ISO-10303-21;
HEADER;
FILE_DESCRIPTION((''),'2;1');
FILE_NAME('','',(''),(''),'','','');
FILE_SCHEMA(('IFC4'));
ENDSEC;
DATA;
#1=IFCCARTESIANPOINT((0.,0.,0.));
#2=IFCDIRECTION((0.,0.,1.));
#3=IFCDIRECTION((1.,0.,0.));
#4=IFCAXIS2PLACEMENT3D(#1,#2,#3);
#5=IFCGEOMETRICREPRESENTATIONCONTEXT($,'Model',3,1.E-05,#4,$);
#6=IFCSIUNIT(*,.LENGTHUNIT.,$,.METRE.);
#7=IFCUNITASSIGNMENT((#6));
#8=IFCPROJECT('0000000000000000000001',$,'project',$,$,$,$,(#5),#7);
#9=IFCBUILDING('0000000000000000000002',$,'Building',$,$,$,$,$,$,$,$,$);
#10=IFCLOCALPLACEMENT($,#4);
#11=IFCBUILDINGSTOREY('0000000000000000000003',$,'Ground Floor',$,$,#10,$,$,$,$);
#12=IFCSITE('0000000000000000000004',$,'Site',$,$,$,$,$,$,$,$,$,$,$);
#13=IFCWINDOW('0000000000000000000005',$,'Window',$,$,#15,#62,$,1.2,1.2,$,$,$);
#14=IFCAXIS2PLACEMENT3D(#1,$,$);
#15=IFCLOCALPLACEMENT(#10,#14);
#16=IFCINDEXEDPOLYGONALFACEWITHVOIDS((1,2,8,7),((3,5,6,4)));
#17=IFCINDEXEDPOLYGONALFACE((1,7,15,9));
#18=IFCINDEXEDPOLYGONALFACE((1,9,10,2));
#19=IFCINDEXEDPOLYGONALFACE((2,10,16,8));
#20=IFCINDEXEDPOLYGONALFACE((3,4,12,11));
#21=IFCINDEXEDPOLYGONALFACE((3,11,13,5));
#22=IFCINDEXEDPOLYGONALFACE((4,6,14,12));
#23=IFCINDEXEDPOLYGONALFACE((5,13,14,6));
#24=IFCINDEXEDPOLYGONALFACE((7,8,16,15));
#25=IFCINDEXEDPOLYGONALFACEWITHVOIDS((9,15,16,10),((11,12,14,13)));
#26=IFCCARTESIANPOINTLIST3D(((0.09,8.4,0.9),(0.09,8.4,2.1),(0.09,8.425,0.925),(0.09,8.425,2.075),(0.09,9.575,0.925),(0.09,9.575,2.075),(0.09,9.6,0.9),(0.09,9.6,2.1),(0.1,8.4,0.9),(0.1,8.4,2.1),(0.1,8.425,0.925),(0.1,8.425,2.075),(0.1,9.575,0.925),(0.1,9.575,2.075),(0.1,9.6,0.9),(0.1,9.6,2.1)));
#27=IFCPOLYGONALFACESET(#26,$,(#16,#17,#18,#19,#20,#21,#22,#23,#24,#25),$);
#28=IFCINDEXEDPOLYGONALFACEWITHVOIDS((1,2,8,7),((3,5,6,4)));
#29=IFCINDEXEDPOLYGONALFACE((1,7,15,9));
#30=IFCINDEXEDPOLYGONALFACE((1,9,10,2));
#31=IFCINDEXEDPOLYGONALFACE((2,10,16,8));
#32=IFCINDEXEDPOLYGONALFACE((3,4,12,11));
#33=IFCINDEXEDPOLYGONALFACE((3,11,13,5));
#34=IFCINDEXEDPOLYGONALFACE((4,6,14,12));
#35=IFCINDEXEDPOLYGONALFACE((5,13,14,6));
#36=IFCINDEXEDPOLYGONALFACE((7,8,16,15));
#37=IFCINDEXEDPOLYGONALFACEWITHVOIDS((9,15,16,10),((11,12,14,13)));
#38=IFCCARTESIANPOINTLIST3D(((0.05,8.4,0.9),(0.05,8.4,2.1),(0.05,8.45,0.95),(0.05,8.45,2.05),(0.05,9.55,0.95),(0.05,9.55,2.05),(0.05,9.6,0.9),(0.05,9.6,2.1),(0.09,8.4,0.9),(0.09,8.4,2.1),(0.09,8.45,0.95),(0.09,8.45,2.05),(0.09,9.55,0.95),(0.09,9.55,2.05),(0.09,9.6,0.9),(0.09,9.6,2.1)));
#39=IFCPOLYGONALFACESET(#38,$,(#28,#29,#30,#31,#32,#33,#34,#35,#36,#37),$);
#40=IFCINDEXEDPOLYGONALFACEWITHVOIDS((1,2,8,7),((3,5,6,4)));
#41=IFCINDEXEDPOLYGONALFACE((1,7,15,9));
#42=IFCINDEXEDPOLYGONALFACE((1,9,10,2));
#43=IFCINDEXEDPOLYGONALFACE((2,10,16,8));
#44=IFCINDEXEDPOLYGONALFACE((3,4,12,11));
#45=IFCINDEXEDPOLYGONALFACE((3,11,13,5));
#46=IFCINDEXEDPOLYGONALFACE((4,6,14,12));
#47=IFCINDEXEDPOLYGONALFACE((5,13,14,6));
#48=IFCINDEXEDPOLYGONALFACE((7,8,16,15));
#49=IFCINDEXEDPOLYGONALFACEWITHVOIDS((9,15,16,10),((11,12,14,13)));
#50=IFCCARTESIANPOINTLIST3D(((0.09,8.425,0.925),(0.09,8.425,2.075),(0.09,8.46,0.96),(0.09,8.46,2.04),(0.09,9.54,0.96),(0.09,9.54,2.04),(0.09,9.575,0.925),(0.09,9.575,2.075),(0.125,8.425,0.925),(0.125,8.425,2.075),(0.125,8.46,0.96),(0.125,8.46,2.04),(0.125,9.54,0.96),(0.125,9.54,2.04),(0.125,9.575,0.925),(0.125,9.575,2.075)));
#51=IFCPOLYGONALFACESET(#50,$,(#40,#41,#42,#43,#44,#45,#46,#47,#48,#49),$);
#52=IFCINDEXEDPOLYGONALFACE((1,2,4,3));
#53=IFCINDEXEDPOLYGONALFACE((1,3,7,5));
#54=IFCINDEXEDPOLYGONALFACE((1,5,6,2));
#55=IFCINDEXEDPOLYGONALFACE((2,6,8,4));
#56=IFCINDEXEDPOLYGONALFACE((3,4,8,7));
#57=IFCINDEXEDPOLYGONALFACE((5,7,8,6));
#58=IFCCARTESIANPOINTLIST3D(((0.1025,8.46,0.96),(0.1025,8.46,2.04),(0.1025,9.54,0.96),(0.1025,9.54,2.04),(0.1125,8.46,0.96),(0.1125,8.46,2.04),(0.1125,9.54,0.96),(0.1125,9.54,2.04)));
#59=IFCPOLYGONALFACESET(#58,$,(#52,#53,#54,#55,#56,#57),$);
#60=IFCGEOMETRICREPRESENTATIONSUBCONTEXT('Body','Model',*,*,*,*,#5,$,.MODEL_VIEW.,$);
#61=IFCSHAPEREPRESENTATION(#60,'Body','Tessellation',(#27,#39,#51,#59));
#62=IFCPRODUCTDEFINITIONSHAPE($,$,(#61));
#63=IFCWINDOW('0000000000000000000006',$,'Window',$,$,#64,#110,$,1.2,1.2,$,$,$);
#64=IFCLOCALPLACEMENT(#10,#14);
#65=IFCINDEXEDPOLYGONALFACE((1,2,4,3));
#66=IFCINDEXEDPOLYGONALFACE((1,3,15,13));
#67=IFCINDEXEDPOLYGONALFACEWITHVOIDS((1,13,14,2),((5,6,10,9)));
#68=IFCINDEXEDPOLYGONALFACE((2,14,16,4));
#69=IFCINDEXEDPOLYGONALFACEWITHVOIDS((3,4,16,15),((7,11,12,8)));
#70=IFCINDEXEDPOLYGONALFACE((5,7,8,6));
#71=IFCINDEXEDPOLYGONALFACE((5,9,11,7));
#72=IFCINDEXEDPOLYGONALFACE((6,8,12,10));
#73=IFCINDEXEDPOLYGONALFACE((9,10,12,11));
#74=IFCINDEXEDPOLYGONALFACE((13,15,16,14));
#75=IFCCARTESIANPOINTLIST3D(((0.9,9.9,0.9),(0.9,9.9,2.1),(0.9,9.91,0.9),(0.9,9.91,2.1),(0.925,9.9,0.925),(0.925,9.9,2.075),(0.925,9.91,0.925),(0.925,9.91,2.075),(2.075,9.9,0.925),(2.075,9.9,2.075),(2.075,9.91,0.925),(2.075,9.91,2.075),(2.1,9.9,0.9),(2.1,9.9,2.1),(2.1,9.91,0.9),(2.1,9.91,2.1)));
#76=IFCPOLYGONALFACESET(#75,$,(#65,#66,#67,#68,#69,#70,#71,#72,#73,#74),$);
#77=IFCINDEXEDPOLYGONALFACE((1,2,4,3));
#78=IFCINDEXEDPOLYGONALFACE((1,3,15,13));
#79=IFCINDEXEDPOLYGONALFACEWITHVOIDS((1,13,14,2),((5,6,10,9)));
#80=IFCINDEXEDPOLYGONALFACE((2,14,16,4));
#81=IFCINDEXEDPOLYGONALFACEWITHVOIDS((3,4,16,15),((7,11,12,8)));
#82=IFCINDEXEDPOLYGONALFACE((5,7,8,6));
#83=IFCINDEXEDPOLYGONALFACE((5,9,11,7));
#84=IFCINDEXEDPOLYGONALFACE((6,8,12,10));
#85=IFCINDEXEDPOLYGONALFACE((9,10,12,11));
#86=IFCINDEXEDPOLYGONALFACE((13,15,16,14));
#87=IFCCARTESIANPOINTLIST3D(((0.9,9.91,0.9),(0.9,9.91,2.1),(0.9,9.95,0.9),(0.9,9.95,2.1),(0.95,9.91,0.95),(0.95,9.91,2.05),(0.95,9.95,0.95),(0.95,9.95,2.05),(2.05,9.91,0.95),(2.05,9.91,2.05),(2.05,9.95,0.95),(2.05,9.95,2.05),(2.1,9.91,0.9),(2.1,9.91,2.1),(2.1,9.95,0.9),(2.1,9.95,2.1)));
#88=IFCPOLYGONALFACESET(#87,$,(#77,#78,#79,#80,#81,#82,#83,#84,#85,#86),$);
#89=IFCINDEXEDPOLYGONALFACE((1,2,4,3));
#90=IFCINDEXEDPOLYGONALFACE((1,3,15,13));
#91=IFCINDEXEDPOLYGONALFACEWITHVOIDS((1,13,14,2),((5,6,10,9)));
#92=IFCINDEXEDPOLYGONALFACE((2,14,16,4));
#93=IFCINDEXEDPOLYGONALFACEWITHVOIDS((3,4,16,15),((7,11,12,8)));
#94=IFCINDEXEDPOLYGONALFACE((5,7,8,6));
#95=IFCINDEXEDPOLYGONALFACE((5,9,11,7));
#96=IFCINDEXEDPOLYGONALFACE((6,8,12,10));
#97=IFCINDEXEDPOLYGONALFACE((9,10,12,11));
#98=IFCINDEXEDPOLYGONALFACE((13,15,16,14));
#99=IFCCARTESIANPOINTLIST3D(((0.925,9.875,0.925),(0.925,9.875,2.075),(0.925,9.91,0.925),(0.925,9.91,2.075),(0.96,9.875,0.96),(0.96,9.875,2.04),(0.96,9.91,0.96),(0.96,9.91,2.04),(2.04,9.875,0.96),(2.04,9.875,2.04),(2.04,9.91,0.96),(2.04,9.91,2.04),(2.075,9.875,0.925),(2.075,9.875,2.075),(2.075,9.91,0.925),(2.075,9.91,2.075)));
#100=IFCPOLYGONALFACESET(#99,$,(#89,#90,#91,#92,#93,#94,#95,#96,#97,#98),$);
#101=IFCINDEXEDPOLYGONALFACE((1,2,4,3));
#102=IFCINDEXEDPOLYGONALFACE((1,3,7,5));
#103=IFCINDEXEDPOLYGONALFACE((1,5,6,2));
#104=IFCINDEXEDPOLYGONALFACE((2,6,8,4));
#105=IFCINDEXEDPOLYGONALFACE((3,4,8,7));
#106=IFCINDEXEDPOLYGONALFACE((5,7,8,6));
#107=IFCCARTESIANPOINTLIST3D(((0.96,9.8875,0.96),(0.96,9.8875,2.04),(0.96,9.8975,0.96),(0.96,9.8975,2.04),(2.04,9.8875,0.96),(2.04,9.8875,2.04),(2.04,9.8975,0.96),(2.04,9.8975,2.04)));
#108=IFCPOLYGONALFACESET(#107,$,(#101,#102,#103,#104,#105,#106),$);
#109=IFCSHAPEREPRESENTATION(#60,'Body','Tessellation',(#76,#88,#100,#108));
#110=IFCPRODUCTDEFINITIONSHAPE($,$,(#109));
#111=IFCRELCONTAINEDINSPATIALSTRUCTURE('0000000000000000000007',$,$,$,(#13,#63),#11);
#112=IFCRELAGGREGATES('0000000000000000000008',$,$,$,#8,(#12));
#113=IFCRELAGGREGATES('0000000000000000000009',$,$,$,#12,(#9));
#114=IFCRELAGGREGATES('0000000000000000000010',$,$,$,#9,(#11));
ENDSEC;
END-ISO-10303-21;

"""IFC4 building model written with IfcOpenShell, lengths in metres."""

from ifc_helpers import new_model, si_unit, frame, origin_with_axes, place, context, subcontext, project, spatial, line, indexed_curve, outline, extrude, element, save


model = new_model("IFC4")

# Units and contexts
model_context = context("Model", 3, precision=1e-05, world=origin_with_axes())
body_context = subcontext(model_context, "Body", "Model", "MODEL_VIEW")
ifc_project = project(units=[si_unit("LENGTHUNIT", "METRE")], contexts=[model_context])

# Site, building, storey
site = spatial("IfcSite", under=ifc_project, Name="Site")
building = spatial("IfcBuilding", under=site, Name="Building")
storey_placement = place(None, origin_with_axes())
storey = spatial("IfcBuildingStorey", under=building, at=storey_placement, Name="Ground Floor")

# Windows
for number, where, z_axis, x_axis, name in (
    (1, (0.0, 9.6, 0.9), (0.0, 0.0, 1.0), (0.0, -1.0, 0.0), "Window"),
    (2, (2.1, 10.0, 0.9), (0.0, 0.0, 1.0), (-1.0, 0.0, 0.0), "Window"),
):
    element("IfcWindow", number, at=place(storey_placement, frame(where, z_axis=z_axis, x_axis=x_axis)), inside=storey, Name=name, OverallHeight=1.2, OverallWidth=1.2, context=body_context, shape_type="SweptSolid", body=[
        extrude(outline(indexed_curve([(0.0, 0.0), (1.2, 0.0), (1.2, 1.2), (0.0, 1.2)], segments=[line(1, 2, 3, 4, 1)]), holes=[indexed_curve([(0.025, 0.025), (1.175, 0.025), (1.175, 1.175), (0.025, 1.175)], segments=[line(1, 2, 3, 4, 1)])]), frame((0.0, 0.09, 0.0), z_axis=(0.0, -1.0, 0.0), x_axis=(1.0, 0.0, 0.0)), (0.0, 0.0, -1.0), 0.01),
        extrude(outline(indexed_curve([(0.0, 0.0), (1.2, 0.0), (1.2, 1.2), (0.0, 1.2)], segments=[line(1, 2, 3, 4, 1)]), holes=[indexed_curve([(0.05, 0.05), (1.15, 0.05), (1.15, 1.15), (0.05, 1.15)], segments=[line(1, 2, 3, 4, 1)])]), frame((0.0, 0.05, 0.0), z_axis=(0.0, -1.0, 0.0), x_axis=(1.0, 0.0, 0.0)), (0.0, 0.0, -1.0), 0.04),
        extrude(outline(indexed_curve([(0.0, 0.0), (1.15, 0.0), (1.15, 1.15), (0.0, 1.15)], segments=[line(1, 2, 3, 4, 1)]), holes=[indexed_curve([(0.035, 0.035), (1.115, 0.035), (1.115, 1.115), (0.035, 1.115)], segments=[line(1, 2, 3, 4, 1)])]), frame((0.025, 0.09, 0.025), z_axis=(0.0, -1.0, 0.0), x_axis=(1.0, 0.0, 0.0)), (0.0, 0.0, -1.0), 0.035),
        extrude(outline(indexed_curve([(0.035, 0.035), (1.115, 0.035), (1.115, 1.115), (0.035, 1.115)], segments=[line(1, 2, 3, 4, 1)])), frame((0.025, 0.1025, 0.025), z_axis=(0.0, -1.0, 0.0), x_axis=(1.0, 0.0, 0.0)), (0.0, 0.0, -1.0), 0.01),
    ])

save(model, "model.ifc")
